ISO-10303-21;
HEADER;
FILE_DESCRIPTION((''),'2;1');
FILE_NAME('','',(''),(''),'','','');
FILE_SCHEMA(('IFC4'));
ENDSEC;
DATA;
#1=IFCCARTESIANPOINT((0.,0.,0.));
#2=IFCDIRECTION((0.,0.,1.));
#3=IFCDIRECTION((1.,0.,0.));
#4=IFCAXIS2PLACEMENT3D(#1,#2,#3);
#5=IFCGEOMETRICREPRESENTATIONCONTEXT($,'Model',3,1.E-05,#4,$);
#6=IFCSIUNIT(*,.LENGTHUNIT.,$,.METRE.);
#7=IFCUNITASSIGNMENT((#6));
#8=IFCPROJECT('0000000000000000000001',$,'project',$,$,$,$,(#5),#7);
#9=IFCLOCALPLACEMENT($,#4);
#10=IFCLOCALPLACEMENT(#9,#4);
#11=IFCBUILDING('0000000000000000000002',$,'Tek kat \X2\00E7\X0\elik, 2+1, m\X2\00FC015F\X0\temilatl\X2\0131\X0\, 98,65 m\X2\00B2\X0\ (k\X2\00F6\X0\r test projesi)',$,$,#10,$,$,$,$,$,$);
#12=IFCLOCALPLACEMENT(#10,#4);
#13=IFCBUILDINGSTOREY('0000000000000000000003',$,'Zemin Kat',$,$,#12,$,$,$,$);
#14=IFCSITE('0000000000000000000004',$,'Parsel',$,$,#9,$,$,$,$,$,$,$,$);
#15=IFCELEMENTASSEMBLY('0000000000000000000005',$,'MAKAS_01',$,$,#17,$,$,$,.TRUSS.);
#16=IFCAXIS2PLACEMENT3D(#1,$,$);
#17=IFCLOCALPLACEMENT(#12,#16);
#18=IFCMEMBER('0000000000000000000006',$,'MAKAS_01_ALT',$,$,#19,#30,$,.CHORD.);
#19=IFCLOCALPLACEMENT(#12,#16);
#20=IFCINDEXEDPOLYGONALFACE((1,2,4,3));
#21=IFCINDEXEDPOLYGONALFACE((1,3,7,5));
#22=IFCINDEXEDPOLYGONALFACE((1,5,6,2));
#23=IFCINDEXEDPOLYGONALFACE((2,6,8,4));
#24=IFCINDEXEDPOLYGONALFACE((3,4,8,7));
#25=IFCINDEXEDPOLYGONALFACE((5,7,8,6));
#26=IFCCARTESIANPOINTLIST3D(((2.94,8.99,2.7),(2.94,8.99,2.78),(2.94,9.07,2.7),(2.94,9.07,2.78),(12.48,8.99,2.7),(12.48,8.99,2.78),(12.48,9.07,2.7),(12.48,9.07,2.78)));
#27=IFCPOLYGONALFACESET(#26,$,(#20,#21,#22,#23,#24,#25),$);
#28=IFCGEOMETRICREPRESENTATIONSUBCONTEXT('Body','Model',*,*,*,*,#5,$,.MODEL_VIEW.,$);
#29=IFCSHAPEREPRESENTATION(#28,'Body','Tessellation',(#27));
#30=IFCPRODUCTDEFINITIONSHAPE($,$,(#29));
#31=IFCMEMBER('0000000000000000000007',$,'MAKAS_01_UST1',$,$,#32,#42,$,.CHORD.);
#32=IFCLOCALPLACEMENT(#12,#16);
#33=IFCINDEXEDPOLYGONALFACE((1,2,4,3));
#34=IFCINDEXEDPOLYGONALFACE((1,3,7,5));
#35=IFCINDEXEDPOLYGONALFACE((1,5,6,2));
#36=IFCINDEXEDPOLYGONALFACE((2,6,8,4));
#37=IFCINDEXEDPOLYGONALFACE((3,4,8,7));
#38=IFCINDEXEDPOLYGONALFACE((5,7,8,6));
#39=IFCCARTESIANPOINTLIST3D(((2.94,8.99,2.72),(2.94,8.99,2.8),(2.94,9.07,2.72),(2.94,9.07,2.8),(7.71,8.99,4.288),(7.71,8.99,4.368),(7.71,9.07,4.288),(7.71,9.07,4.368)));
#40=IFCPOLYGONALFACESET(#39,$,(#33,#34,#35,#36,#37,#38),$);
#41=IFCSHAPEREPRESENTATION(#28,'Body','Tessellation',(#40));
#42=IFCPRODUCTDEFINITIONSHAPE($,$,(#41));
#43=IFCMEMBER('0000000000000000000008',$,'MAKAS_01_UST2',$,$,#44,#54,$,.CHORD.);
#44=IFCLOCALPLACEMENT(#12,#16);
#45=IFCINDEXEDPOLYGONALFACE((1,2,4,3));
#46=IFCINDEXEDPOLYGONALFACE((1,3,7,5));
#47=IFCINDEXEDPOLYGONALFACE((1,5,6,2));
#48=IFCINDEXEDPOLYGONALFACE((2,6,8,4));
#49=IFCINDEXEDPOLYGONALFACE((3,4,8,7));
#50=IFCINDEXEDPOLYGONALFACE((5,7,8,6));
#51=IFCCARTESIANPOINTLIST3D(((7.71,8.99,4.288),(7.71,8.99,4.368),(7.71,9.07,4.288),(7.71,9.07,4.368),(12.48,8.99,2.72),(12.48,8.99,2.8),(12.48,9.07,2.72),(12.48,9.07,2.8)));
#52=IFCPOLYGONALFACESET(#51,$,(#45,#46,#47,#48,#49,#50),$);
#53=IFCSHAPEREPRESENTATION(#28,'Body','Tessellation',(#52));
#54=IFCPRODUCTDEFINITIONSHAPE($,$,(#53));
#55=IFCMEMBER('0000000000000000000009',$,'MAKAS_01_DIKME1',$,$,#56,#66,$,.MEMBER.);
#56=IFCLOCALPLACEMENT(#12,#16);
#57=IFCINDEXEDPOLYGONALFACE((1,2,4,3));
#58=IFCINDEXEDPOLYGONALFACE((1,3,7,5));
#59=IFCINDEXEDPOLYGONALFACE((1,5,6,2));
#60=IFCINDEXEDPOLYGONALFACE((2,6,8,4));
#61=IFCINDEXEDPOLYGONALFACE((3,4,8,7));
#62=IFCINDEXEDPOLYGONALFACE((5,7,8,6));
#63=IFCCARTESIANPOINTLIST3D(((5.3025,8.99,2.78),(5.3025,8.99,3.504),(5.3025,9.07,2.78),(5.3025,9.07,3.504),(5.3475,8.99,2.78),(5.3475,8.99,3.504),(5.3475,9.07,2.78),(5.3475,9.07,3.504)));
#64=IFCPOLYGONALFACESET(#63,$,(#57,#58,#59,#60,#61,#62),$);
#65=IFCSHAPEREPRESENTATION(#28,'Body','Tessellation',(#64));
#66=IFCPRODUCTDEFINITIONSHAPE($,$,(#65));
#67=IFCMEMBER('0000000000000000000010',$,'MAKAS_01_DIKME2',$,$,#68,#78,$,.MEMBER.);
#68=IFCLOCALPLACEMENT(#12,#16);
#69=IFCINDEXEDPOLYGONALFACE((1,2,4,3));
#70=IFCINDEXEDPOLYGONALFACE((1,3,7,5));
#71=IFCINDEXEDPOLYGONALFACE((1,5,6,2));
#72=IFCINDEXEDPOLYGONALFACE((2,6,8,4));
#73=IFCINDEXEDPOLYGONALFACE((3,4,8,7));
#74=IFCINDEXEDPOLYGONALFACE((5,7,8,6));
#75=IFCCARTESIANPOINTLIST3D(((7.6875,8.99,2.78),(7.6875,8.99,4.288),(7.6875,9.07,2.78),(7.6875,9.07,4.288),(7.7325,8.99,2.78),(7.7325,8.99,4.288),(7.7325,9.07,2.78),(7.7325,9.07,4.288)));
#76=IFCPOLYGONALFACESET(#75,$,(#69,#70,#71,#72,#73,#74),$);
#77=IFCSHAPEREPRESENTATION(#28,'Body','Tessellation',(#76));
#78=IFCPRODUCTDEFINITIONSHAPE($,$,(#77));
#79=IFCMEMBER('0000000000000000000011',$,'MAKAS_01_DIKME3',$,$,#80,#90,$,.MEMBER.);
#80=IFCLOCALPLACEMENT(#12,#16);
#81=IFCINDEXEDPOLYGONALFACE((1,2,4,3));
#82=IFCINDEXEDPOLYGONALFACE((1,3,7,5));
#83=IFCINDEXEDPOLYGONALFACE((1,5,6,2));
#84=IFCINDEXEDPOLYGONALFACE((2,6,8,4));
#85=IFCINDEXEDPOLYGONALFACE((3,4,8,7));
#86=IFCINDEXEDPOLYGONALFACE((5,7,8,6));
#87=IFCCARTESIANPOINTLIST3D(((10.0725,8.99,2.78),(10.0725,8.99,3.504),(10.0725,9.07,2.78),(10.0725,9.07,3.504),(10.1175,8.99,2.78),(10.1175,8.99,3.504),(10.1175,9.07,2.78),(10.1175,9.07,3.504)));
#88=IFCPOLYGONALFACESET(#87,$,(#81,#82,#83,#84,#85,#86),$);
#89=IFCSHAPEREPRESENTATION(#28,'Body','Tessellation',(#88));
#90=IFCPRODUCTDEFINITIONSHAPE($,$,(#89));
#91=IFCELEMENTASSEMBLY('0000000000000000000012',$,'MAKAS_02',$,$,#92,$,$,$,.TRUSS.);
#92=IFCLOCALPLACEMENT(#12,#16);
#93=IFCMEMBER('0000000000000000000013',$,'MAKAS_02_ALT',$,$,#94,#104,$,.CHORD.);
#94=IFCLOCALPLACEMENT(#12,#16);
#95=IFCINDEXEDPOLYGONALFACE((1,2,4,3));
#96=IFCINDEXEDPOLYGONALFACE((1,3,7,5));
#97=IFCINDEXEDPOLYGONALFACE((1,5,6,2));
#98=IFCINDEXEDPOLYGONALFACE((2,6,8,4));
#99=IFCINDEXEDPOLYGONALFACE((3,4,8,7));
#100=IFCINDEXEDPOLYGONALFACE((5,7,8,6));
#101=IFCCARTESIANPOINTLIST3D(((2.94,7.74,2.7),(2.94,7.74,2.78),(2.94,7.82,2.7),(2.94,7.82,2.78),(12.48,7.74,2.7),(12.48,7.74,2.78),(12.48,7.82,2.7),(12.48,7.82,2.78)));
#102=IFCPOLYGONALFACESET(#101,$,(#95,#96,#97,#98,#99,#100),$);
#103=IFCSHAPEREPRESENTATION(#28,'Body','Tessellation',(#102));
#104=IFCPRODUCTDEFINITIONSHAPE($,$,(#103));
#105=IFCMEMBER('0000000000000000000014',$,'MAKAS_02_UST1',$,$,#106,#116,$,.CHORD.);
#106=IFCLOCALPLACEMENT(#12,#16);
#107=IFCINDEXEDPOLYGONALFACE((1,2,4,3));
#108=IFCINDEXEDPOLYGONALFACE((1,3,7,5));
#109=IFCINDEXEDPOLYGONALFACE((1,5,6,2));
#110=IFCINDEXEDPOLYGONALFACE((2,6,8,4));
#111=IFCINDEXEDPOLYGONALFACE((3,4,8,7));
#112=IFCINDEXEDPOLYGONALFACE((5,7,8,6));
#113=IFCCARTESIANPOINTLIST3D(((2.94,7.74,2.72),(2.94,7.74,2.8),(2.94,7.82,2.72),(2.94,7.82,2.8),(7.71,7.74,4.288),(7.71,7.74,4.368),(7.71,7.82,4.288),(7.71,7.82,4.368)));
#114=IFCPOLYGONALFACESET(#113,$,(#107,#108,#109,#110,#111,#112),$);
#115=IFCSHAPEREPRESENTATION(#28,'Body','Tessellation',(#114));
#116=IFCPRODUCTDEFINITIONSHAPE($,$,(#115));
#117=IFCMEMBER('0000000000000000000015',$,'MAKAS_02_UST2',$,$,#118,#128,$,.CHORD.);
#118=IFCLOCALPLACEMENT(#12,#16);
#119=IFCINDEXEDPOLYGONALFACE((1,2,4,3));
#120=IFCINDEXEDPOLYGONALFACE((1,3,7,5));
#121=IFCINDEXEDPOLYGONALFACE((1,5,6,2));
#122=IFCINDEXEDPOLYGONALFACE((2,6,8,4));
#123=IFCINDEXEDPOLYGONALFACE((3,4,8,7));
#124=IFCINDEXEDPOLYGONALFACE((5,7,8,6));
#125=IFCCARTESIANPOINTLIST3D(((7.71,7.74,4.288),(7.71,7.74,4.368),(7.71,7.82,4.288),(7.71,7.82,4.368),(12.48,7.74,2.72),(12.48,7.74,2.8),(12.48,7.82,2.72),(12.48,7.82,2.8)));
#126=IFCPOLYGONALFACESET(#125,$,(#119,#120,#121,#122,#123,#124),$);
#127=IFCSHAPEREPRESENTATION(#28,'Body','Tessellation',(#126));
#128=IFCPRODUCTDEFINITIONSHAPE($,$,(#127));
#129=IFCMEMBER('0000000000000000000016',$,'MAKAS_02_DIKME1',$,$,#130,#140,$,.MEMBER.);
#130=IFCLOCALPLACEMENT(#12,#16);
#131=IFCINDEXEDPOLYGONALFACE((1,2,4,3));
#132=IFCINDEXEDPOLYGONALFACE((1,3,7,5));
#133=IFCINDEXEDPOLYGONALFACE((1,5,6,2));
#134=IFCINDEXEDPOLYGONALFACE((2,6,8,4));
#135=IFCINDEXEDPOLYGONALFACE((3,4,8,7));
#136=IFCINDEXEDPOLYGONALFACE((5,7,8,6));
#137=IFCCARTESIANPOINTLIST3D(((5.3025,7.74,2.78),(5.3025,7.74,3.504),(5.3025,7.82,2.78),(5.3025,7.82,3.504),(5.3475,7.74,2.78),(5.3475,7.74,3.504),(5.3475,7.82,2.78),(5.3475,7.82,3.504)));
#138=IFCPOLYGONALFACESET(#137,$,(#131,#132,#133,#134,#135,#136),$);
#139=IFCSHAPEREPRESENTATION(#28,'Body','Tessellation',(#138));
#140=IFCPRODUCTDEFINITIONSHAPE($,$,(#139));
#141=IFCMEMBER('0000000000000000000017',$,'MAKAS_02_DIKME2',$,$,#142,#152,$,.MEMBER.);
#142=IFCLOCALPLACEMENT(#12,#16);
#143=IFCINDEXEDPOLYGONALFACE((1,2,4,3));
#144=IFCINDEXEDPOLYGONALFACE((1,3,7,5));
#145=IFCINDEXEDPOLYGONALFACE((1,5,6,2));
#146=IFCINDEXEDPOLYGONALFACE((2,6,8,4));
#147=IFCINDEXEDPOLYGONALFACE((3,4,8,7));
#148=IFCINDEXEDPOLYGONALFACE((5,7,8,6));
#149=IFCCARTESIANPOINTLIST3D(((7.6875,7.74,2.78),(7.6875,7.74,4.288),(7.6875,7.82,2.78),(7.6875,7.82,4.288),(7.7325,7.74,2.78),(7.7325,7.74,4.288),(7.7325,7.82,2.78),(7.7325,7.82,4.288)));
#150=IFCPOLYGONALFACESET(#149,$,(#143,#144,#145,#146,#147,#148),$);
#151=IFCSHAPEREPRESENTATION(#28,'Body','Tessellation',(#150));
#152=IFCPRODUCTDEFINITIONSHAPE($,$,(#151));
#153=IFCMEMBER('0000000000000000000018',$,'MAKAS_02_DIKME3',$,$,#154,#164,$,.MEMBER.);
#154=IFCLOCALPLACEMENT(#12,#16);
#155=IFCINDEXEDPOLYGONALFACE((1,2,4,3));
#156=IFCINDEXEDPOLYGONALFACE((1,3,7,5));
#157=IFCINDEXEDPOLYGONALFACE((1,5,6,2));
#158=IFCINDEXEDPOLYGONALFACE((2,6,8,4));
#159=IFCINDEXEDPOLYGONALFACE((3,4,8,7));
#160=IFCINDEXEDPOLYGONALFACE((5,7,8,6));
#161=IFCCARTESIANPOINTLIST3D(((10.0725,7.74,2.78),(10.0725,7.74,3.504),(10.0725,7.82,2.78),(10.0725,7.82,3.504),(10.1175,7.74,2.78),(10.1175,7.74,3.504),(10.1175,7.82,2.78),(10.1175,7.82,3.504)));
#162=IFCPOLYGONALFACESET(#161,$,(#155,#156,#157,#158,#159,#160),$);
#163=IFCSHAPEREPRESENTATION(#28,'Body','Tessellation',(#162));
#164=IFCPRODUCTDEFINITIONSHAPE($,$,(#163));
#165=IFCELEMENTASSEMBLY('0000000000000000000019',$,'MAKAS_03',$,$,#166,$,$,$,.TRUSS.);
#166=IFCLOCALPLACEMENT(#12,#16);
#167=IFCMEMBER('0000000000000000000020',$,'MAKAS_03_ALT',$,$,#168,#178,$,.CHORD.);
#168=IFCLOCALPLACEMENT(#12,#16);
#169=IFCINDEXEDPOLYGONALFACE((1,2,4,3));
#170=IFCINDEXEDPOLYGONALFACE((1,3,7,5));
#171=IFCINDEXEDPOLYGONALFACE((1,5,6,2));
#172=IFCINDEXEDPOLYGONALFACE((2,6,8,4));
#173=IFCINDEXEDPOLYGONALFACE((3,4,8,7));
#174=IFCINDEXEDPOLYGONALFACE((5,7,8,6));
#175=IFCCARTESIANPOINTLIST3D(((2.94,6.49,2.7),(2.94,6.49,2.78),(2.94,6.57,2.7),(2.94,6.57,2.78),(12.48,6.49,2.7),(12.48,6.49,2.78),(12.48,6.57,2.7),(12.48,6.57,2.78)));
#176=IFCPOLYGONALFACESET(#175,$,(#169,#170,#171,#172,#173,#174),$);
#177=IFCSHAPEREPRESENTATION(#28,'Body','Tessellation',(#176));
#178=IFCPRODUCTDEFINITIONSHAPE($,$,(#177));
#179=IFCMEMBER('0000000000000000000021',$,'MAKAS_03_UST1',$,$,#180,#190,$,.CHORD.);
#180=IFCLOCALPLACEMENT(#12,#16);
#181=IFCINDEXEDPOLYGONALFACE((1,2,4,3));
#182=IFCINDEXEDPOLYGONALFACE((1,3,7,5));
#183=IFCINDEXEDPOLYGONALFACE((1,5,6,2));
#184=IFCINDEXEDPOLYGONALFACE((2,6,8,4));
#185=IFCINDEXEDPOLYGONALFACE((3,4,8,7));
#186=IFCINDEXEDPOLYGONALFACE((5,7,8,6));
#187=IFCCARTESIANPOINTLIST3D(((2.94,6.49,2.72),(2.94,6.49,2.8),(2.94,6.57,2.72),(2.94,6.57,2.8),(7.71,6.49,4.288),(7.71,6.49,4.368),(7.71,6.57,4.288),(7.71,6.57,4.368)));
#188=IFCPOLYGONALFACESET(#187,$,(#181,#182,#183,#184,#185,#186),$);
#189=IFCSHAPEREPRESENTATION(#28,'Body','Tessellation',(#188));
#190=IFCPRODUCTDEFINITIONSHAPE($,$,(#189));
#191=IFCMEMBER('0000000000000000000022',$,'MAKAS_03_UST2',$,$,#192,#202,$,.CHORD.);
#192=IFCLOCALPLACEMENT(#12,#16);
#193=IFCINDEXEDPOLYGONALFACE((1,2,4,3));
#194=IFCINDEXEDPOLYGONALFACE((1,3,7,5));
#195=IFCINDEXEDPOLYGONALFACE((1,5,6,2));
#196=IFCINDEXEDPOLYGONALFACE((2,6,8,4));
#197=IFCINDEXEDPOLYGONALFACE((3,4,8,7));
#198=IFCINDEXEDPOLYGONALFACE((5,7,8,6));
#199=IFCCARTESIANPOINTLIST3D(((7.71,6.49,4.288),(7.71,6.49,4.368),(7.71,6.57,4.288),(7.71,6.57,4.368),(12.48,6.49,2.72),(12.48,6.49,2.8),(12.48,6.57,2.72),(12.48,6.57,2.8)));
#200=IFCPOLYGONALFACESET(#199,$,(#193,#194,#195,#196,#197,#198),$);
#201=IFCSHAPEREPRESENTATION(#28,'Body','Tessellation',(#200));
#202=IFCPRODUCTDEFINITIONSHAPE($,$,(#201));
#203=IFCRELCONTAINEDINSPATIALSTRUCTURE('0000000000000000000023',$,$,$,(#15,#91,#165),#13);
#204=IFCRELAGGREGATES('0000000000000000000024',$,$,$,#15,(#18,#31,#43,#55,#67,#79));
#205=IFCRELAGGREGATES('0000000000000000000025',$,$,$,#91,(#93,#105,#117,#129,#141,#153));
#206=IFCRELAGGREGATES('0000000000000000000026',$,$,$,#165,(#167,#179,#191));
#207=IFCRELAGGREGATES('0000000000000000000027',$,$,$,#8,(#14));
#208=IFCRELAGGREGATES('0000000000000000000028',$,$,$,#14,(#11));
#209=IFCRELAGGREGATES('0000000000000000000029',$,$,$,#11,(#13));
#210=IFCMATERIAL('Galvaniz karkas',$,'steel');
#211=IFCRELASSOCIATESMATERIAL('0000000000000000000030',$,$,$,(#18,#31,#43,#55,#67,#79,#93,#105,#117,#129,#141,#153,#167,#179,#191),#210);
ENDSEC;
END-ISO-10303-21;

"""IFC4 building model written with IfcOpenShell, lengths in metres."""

from ifc_helpers import new_model, si_unit, frame, origin_with_axes, place, context, subcontext, project, spatial, line, indexed_curve, outline, extrude, material, element, aggregate, save


model = new_model("IFC4")

# Units and contexts
model_context = context("Model", 3, precision=1e-05, world=origin_with_axes())
body_context = subcontext(model_context, "Body", "Model", "MODEL_VIEW")
ifc_project = project(units=[si_unit("LENGTHUNIT", "METRE")], contexts=[model_context])

# Site, building, storey
site_placement = place(None, origin_with_axes())
site = spatial("IfcSite", under=ifc_project, at=site_placement, Name="Parsel")
building_placement = place(site_placement, origin_with_axes())
building = spatial("IfcBuilding", under=site, at=building_placement, Name="Tek kat çelik, 2+1, müştemilatlı, 98,65 m² (kör test projesi)")
storey_placement = place(building_placement, origin_with_axes())
storey = spatial("IfcBuildingStorey", under=building, at=storey_placement, Name="Zemin Kat")

# Element assemblies, members
assembly_1_placement = place(storey_placement, origin_with_axes())
assembly_1 = element("IfcElementAssembly", 1, at=assembly_1_placement, inside=storey, Name="MAKAS_01", PredefinedType="TRUSS")
ifc_material_1 = material(Name="Galvaniz karkas", Category="steel")
member_1_placement = place(assembly_1_placement, origin_with_axes())
member_1 = element("IfcMember", 2, at=member_1_placement, material=ifc_material_1, Name="MAKAS_01_ALT", PredefinedType="CHORD", context=body_context, shape_type="SweptSolid", body=[
    extrude(outline(indexed_curve([(2.94, 2.7), (12.48, 2.7), (12.48, 2.78), (2.94, 2.78)], segments=[line(1, 2, 3, 4, 1)])), frame((0.0, 9.07, 0.0), z_axis=(0.0, -1.0, 0.0), x_axis=(1.0, 0.0, 0.0)), (0.0, 0.0, 1.0), 0.08),
])
member_2_placement = place(assembly_1_placement, origin_with_axes())
member_2 = element("IfcMember", 3, at=member_2_placement, material=ifc_material_1, Name="MAKAS_01_UST1", PredefinedType="CHORD", context=body_context, shape_type="SweptSolid", body=[
    extrude(outline(indexed_curve([(2.94, 2.72), (7.71, 4.288), (7.71, 4.368), (2.94, 2.8)], segments=[line(1, 2, 3, 4, 1)])), frame((0.0, 9.07, 0.0), z_axis=(0.0, -1.0, 0.0), x_axis=(1.0, 0.0, 0.0)), (0.0, 0.0, 1.0), 0.08),
])
member_3_placement = place(assembly_1_placement, origin_with_axes())
member_3 = element("IfcMember", 4, at=member_3_placement, material=ifc_material_1, Name="MAKAS_01_UST2", PredefinedType="CHORD", context=body_context, shape_type="SweptSolid", body=[
    extrude(outline(indexed_curve([(7.71, 4.288), (12.48, 2.72), (12.48, 2.8), (7.71, 4.368)], segments=[line(1, 2, 3, 4, 1)])), frame((0.0, 9.07, 0.0), z_axis=(0.0, -1.0, 0.0), x_axis=(1.0, 0.0, 0.0)), (0.0, 0.0, 1.0), 0.08),
])
member_4_placement = place(assembly_1_placement, origin_with_axes())
member_4 = element("IfcMember", 5, at=member_4_placement, material=ifc_material_1, Name="MAKAS_01_DIKME1", PredefinedType="MEMBER", context=body_context, shape_type="SweptSolid", body=[
    extrude(outline(indexed_curve([(5.3025, 2.78), (5.3475, 2.78), (5.3475, 3.504), (5.3025, 3.504)], segments=[line(1, 2, 3, 4, 1)])), frame((0.0, 9.07, 0.0), z_axis=(0.0, -1.0, 0.0), x_axis=(1.0, 0.0, 0.0)), (0.0, 0.0, 1.0), 0.08),
])
member_5_placement = place(assembly_1_placement, origin_with_axes())
member_5 = element("IfcMember", 6, at=member_5_placement, material=ifc_material_1, Name="MAKAS_01_DIKME2", PredefinedType="MEMBER", context=body_context, shape_type="SweptSolid", body=[
    extrude(outline(indexed_curve([(7.6875, 2.78), (7.7325, 2.78), (7.7325, 4.288), (7.6875, 4.288)], segments=[line(1, 2, 3, 4, 1)])), frame((0.0, 9.07, 0.0), z_axis=(0.0, -1.0, 0.0), x_axis=(1.0, 0.0, 0.0)), (0.0, 0.0, 1.0), 0.08),
])
member_6_placement = place(assembly_1_placement, origin_with_axes())
member_6 = element("IfcMember", 7, at=member_6_placement, material=ifc_material_1, Name="MAKAS_01_DIKME3", PredefinedType="MEMBER", context=body_context, shape_type="SweptSolid", body=[
    extrude(outline(indexed_curve([(10.0725, 2.78), (10.1175, 2.78), (10.1175, 3.504), (10.0725, 3.504)], segments=[line(1, 2, 3, 4, 1)])), frame((0.0, 9.07, 0.0), z_axis=(0.0, -1.0, 0.0), x_axis=(1.0, 0.0, 0.0)), (0.0, 0.0, 1.0), 0.08),
])
aggregate(assembly_1, [member_1, member_2, member_3, member_4, member_5, member_6])
assembly_2_placement = place(storey_placement, origin_with_axes())
assembly_2 = element("IfcElementAssembly", 8, at=assembly_2_placement, inside=storey, Name="MAKAS_02", PredefinedType="TRUSS")
member_7_placement = place(assembly_2_placement, origin_with_axes())
member_7 = element("IfcMember", 9, at=member_7_placement, material=ifc_material_1, Name="MAKAS_02_ALT", PredefinedType="CHORD", context=body_context, shape_type="SweptSolid", body=[
    extrude(outline(indexed_curve([(2.94, 2.7), (12.48, 2.7), (12.48, 2.78), (2.94, 2.78)], segments=[line(1, 2, 3, 4, 1)])), frame((0.0, 7.82, 0.0), z_axis=(0.0, -1.0, 0.0), x_axis=(1.0, 0.0, 0.0)), (0.0, 0.0, 1.0), 0.08),
])
member_8_placement = place(assembly_2_placement, origin_with_axes())
member_8 = element("IfcMember", 10, at=member_8_placement, material=ifc_material_1, Name="MAKAS_02_UST1", PredefinedType="CHORD", context=body_context, shape_type="SweptSolid", body=[
    extrude(outline(indexed_curve([(2.94, 2.72), (7.71, 4.288), (7.71, 4.368), (2.94, 2.8)], segments=[line(1, 2, 3, 4, 1)])), frame((0.0, 7.82, 0.0), z_axis=(0.0, -1.0, 0.0), x_axis=(1.0, 0.0, 0.0)), (0.0, 0.0, 1.0), 0.08),
])
member_9_placement = place(assembly_2_placement, origin_with_axes())
member_9 = element("IfcMember", 11, at=member_9_placement, material=ifc_material_1, Name="MAKAS_02_UST2", PredefinedType="CHORD", context=body_context, shape_type="SweptSolid", body=[
    extrude(outline(indexed_curve([(7.71, 4.288), (12.48, 2.72), (12.48, 2.8), (7.71, 4.368)], segments=[line(1, 2, 3, 4, 1)])), frame((0.0, 7.82, 0.0), z_axis=(0.0, -1.0, 0.0), x_axis=(1.0, 0.0, 0.0)), (0.0, 0.0, 1.0), 0.08),
])
member_10_placement = place(assembly_2_placement, origin_with_axes())
member_10 = element("IfcMember", 12, at=member_10_placement, material=ifc_material_1, Name="MAKAS_02_DIKME1", PredefinedType="MEMBER", context=body_context, shape_type="SweptSolid", body=[
    extrude(outline(indexed_curve([(5.3025, 2.78), (5.3475, 2.78), (5.3475, 3.504), (5.3025, 3.504)], segments=[line(1, 2, 3, 4, 1)])), frame((0.0, 7.82, 0.0), z_axis=(0.0, -1.0, 0.0), x_axis=(1.0, 0.0, 0.0)), (0.0, 0.0, 1.0), 0.08),
])
member_11_placement = place(assembly_2_placement, origin_with_axes())
member_11 = element("IfcMember", 13, at=member_11_placement, material=ifc_material_1, Name="MAKAS_02_DIKME2", PredefinedType="MEMBER", context=body_context, shape_type="SweptSolid", body=[
    extrude(outline(indexed_curve([(7.6875, 2.78), (7.7325, 2.78), (7.7325, 4.288), (7.6875, 4.288)], segments=[line(1, 2, 3, 4, 1)])), frame((0.0, 7.82, 0.0), z_axis=(0.0, -1.0, 0.0), x_axis=(1.0, 0.0, 0.0)), (0.0, 0.0, 1.0), 0.08),
])
member_12_placement = place(assembly_2_placement, origin_with_axes())
member_12 = element("IfcMember", 14, at=member_12_placement, material=ifc_material_1, Name="MAKAS_02_DIKME3", PredefinedType="MEMBER", context=body_context, shape_type="SweptSolid", body=[
    extrude(outline(indexed_curve([(10.0725, 2.78), (10.1175, 2.78), (10.1175, 3.504), (10.0725, 3.504)], segments=[line(1, 2, 3, 4, 1)])), frame((0.0, 7.82, 0.0), z_axis=(0.0, -1.0, 0.0), x_axis=(1.0, 0.0, 0.0)), (0.0, 0.0, 1.0), 0.08),
])
aggregate(assembly_2, [member_7, member_8, member_9, member_10, member_11, member_12])
assembly_3_placement = place(storey_placement, origin_with_axes())
assembly_3 = element("IfcElementAssembly", 15, at=assembly_3_placement, inside=storey, Name="MAKAS_03", PredefinedType="TRUSS")
member_13_placement = place(assembly_3_placement, origin_with_axes())
member_13 = element("IfcMember", 16, at=member_13_placement, material=ifc_material_1, Name="MAKAS_03_ALT", PredefinedType="CHORD", context=body_context, shape_type="SweptSolid", body=[
    extrude(outline(indexed_curve([(2.94, 2.7), (12.48, 2.7), (12.48, 2.78), (2.94, 2.78)], segments=[line(1, 2, 3, 4, 1)])), frame((0.0, 6.57, 0.0), z_axis=(0.0, -1.0, 0.0), x_axis=(1.0, 0.0, 0.0)), (0.0, 0.0, 1.0), 0.08),
])
member_14_placement = place(assembly_3_placement, origin_with_axes())
member_14 = element("IfcMember", 17, at=member_14_placement, material=ifc_material_1, Name="MAKAS_03_UST1", PredefinedType="CHORD", context=body_context, shape_type="SweptSolid", body=[
    extrude(outline(indexed_curve([(2.94, 2.72), (7.71, 4.288), (7.71, 4.368), (2.94, 2.8)], segments=[line(1, 2, 3, 4, 1)])), frame((0.0, 6.57, 0.0), z_axis=(0.0, -1.0, 0.0), x_axis=(1.0, 0.0, 0.0)), (0.0, 0.0, 1.0), 0.08),
])
member_15_placement = place(assembly_3_placement, origin_with_axes())
member_15 = element("IfcMember", 18, at=member_15_placement, material=ifc_material_1, Name="MAKAS_03_UST2", PredefinedType="CHORD", context=body_context, shape_type="SweptSolid", body=[
    extrude(outline(indexed_curve([(7.71, 4.288), (12.48, 2.72), (12.48, 2.8), (7.71, 4.368)], segments=[line(1, 2, 3, 4, 1)])), frame((0.0, 6.57, 0.0), z_axis=(0.0, -1.0, 0.0), x_axis=(1.0, 0.0, 0.0)), (0.0, 0.0, 1.0), 0.08),
])
aggregate(assembly_3, [member_13, member_14, member_15])

save(model, "model.ifc")
